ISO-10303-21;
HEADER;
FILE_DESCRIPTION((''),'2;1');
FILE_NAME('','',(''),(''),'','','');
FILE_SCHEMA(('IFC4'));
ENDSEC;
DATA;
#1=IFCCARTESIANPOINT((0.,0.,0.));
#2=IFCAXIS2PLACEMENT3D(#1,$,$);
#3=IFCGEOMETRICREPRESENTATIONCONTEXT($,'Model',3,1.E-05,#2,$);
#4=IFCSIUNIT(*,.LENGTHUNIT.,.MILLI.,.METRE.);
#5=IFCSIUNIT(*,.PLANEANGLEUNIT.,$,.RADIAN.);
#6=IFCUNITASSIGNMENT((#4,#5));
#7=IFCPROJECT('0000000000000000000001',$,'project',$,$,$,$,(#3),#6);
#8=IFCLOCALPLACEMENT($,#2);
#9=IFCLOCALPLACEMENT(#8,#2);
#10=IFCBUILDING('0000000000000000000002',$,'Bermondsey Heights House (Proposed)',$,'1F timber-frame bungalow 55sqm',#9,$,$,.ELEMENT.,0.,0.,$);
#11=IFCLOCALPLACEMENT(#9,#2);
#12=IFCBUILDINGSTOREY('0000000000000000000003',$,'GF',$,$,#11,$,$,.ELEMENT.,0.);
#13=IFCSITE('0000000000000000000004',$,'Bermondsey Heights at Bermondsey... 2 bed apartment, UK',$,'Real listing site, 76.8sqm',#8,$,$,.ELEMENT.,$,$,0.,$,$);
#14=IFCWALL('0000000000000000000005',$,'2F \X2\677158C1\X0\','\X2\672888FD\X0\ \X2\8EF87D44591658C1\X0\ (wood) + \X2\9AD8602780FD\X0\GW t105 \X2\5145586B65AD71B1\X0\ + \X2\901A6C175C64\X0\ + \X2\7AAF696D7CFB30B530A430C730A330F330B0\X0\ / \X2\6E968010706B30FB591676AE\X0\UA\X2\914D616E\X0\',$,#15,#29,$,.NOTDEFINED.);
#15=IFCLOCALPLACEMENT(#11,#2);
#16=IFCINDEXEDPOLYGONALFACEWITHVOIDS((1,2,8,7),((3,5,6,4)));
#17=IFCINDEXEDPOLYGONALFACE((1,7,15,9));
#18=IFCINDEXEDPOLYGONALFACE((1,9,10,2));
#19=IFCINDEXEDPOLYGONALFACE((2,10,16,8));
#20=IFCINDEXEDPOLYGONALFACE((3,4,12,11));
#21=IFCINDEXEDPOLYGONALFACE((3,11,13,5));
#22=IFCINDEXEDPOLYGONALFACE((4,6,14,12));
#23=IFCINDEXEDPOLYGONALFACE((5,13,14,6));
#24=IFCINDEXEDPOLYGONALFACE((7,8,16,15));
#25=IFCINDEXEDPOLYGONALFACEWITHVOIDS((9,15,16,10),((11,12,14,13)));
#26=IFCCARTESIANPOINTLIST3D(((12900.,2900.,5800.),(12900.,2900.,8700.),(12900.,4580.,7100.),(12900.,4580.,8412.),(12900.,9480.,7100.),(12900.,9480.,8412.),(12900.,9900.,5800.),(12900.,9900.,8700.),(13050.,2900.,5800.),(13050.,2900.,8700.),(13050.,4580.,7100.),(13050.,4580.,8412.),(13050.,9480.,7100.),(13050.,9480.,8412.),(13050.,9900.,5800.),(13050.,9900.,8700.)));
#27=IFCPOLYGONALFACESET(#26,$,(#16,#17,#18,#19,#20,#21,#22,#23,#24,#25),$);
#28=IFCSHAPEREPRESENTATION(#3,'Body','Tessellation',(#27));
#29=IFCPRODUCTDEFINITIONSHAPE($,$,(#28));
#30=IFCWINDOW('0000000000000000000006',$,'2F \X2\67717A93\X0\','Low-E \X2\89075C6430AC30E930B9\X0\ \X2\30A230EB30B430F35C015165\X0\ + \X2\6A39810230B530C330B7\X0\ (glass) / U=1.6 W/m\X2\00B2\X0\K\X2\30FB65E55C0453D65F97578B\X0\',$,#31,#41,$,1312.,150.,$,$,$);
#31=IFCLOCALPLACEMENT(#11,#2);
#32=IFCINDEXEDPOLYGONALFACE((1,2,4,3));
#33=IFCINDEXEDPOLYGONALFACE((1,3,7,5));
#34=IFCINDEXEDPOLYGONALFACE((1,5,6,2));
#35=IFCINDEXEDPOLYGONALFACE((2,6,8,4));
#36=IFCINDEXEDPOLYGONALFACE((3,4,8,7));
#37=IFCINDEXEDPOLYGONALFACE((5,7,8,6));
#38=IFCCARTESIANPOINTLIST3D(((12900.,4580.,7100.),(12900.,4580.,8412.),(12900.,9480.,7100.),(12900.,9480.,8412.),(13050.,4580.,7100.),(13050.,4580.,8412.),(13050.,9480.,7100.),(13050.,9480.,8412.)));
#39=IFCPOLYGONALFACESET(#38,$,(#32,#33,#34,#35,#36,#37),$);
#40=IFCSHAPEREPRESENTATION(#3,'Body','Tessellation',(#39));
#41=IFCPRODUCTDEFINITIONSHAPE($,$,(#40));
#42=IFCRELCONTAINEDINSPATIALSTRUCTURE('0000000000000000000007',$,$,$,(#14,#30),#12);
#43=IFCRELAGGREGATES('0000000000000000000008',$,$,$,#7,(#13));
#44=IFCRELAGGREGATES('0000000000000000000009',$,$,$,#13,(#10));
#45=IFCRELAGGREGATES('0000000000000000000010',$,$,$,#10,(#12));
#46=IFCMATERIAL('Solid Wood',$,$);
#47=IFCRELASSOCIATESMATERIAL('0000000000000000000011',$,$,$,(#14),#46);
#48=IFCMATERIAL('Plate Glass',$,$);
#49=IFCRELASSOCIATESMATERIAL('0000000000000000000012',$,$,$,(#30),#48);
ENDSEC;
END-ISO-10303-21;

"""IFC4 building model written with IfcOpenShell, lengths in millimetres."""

from ifc_helpers import new_model, si_unit, frame, frame_2d, origin, place, context, project, spatial, rectangle, extrude, material, element, fill, save


model = new_model("IFC4")

# Units and contexts
model_context = context("Model", 3, precision=1e-05, world=origin())
ifc_project = project(units=[si_unit("LENGTHUNIT", "METRE", prefix="MILLI"), si_unit("PLANEANGLEUNIT", "RADIAN")], contexts=[model_context])

# Site, building, storey
site_placement = place(None, origin())
site = spatial("IfcSite", under=ifc_project, at=site_placement, Name="Bermondsey Heights at Bermondsey... 2 bed apartment, UK", ObjectType="Real listing site, 76.8sqm", CompositionType="ELEMENT", RefElevation=0.0)
building_placement = place(site_placement, origin())
building = spatial("IfcBuilding", under=site, at=building_placement, Name="Bermondsey Heights House (Proposed)", ObjectType="1F timber-frame bungalow 55sqm", CompositionType="ELEMENT", ElevationOfRefHeight=0.0, ElevationOfTerrain=0.0)
storey_placement = place(building_placement, origin())
storey = spatial("IfcBuildingStorey", under=building, at=storey_placement, Name="GF", CompositionType="ELEMENT", Elevation=0.0)

# Shared definitions
ifc_material_1 = material(Name="Solid Wood")

# Wall, opening, window
ifc_material_2 = material(Name="Plate Glass")
wall_1_placement = place(storey_placement, frame((6450.0, 1450.0, 2900.0)))
wall_1 = element("IfcWall", 1, at=wall_1_placement, inside=storey, material=ifc_material_1, Name="2F 東壁", Description="木製 軸組外壁 (wood) + 高性能GW t105 充填断熱 + 通気層 + 窯業系サイディング / 準耐火・外皮UA配慮", PredefinedType="NOTDEFINED", context=model_context, shape_type="SweptSolid", body=[
    extrude(rectangle(XDim=150.0, YDim=7000.0, at=frame_2d((75.0, 3500.0))), frame((6450.0, 1450.0, 2900.0)), (0.0, 0.0, 1.0), 2900.0),
])
opening_1_placement = place(storey_placement, frame((6450.0, 2290.0, 3550.0)))
opening_1 = element("IfcOpeningElement", 2, at=opening_1_placement, cuts=wall_1, PredefinedType="NOTDEFINED", context=model_context, shape_type="SweptSolid", body=[
    extrude(rectangle(XDim=150.0, YDim=4900.0, at=frame_2d((75.0, 2450.0))), frame((6450.0, 2290.0, 3550.0)), (0.0, 0.0, 1.0), 1312.0),
])
window_1_placement = place(storey_placement, frame((6450.0, 2290.0, 3550.0)))
window_1 = element("IfcWindow", 3, at=window_1_placement, inside=storey, material=ifc_material_2, Name="2F 東窓", Description="Low-E 複層ガラス アルゴン封入 + 樹脂サッシ (glass) / U=1.6 W/m²K・日射取得型", OverallHeight=1312.0, OverallWidth=150.0, context=model_context, shape_type="SweptSolid", body=[
    extrude(rectangle(XDim=150.0, YDim=4900.0, at=frame_2d((75.0, 2450.0))), frame((6450.0, 2290.0, 3550.0)), (0.0, 0.0, 1.0), 1312.0),
])
fill(opening_1, window_1)

save(model, "model.ifc")
